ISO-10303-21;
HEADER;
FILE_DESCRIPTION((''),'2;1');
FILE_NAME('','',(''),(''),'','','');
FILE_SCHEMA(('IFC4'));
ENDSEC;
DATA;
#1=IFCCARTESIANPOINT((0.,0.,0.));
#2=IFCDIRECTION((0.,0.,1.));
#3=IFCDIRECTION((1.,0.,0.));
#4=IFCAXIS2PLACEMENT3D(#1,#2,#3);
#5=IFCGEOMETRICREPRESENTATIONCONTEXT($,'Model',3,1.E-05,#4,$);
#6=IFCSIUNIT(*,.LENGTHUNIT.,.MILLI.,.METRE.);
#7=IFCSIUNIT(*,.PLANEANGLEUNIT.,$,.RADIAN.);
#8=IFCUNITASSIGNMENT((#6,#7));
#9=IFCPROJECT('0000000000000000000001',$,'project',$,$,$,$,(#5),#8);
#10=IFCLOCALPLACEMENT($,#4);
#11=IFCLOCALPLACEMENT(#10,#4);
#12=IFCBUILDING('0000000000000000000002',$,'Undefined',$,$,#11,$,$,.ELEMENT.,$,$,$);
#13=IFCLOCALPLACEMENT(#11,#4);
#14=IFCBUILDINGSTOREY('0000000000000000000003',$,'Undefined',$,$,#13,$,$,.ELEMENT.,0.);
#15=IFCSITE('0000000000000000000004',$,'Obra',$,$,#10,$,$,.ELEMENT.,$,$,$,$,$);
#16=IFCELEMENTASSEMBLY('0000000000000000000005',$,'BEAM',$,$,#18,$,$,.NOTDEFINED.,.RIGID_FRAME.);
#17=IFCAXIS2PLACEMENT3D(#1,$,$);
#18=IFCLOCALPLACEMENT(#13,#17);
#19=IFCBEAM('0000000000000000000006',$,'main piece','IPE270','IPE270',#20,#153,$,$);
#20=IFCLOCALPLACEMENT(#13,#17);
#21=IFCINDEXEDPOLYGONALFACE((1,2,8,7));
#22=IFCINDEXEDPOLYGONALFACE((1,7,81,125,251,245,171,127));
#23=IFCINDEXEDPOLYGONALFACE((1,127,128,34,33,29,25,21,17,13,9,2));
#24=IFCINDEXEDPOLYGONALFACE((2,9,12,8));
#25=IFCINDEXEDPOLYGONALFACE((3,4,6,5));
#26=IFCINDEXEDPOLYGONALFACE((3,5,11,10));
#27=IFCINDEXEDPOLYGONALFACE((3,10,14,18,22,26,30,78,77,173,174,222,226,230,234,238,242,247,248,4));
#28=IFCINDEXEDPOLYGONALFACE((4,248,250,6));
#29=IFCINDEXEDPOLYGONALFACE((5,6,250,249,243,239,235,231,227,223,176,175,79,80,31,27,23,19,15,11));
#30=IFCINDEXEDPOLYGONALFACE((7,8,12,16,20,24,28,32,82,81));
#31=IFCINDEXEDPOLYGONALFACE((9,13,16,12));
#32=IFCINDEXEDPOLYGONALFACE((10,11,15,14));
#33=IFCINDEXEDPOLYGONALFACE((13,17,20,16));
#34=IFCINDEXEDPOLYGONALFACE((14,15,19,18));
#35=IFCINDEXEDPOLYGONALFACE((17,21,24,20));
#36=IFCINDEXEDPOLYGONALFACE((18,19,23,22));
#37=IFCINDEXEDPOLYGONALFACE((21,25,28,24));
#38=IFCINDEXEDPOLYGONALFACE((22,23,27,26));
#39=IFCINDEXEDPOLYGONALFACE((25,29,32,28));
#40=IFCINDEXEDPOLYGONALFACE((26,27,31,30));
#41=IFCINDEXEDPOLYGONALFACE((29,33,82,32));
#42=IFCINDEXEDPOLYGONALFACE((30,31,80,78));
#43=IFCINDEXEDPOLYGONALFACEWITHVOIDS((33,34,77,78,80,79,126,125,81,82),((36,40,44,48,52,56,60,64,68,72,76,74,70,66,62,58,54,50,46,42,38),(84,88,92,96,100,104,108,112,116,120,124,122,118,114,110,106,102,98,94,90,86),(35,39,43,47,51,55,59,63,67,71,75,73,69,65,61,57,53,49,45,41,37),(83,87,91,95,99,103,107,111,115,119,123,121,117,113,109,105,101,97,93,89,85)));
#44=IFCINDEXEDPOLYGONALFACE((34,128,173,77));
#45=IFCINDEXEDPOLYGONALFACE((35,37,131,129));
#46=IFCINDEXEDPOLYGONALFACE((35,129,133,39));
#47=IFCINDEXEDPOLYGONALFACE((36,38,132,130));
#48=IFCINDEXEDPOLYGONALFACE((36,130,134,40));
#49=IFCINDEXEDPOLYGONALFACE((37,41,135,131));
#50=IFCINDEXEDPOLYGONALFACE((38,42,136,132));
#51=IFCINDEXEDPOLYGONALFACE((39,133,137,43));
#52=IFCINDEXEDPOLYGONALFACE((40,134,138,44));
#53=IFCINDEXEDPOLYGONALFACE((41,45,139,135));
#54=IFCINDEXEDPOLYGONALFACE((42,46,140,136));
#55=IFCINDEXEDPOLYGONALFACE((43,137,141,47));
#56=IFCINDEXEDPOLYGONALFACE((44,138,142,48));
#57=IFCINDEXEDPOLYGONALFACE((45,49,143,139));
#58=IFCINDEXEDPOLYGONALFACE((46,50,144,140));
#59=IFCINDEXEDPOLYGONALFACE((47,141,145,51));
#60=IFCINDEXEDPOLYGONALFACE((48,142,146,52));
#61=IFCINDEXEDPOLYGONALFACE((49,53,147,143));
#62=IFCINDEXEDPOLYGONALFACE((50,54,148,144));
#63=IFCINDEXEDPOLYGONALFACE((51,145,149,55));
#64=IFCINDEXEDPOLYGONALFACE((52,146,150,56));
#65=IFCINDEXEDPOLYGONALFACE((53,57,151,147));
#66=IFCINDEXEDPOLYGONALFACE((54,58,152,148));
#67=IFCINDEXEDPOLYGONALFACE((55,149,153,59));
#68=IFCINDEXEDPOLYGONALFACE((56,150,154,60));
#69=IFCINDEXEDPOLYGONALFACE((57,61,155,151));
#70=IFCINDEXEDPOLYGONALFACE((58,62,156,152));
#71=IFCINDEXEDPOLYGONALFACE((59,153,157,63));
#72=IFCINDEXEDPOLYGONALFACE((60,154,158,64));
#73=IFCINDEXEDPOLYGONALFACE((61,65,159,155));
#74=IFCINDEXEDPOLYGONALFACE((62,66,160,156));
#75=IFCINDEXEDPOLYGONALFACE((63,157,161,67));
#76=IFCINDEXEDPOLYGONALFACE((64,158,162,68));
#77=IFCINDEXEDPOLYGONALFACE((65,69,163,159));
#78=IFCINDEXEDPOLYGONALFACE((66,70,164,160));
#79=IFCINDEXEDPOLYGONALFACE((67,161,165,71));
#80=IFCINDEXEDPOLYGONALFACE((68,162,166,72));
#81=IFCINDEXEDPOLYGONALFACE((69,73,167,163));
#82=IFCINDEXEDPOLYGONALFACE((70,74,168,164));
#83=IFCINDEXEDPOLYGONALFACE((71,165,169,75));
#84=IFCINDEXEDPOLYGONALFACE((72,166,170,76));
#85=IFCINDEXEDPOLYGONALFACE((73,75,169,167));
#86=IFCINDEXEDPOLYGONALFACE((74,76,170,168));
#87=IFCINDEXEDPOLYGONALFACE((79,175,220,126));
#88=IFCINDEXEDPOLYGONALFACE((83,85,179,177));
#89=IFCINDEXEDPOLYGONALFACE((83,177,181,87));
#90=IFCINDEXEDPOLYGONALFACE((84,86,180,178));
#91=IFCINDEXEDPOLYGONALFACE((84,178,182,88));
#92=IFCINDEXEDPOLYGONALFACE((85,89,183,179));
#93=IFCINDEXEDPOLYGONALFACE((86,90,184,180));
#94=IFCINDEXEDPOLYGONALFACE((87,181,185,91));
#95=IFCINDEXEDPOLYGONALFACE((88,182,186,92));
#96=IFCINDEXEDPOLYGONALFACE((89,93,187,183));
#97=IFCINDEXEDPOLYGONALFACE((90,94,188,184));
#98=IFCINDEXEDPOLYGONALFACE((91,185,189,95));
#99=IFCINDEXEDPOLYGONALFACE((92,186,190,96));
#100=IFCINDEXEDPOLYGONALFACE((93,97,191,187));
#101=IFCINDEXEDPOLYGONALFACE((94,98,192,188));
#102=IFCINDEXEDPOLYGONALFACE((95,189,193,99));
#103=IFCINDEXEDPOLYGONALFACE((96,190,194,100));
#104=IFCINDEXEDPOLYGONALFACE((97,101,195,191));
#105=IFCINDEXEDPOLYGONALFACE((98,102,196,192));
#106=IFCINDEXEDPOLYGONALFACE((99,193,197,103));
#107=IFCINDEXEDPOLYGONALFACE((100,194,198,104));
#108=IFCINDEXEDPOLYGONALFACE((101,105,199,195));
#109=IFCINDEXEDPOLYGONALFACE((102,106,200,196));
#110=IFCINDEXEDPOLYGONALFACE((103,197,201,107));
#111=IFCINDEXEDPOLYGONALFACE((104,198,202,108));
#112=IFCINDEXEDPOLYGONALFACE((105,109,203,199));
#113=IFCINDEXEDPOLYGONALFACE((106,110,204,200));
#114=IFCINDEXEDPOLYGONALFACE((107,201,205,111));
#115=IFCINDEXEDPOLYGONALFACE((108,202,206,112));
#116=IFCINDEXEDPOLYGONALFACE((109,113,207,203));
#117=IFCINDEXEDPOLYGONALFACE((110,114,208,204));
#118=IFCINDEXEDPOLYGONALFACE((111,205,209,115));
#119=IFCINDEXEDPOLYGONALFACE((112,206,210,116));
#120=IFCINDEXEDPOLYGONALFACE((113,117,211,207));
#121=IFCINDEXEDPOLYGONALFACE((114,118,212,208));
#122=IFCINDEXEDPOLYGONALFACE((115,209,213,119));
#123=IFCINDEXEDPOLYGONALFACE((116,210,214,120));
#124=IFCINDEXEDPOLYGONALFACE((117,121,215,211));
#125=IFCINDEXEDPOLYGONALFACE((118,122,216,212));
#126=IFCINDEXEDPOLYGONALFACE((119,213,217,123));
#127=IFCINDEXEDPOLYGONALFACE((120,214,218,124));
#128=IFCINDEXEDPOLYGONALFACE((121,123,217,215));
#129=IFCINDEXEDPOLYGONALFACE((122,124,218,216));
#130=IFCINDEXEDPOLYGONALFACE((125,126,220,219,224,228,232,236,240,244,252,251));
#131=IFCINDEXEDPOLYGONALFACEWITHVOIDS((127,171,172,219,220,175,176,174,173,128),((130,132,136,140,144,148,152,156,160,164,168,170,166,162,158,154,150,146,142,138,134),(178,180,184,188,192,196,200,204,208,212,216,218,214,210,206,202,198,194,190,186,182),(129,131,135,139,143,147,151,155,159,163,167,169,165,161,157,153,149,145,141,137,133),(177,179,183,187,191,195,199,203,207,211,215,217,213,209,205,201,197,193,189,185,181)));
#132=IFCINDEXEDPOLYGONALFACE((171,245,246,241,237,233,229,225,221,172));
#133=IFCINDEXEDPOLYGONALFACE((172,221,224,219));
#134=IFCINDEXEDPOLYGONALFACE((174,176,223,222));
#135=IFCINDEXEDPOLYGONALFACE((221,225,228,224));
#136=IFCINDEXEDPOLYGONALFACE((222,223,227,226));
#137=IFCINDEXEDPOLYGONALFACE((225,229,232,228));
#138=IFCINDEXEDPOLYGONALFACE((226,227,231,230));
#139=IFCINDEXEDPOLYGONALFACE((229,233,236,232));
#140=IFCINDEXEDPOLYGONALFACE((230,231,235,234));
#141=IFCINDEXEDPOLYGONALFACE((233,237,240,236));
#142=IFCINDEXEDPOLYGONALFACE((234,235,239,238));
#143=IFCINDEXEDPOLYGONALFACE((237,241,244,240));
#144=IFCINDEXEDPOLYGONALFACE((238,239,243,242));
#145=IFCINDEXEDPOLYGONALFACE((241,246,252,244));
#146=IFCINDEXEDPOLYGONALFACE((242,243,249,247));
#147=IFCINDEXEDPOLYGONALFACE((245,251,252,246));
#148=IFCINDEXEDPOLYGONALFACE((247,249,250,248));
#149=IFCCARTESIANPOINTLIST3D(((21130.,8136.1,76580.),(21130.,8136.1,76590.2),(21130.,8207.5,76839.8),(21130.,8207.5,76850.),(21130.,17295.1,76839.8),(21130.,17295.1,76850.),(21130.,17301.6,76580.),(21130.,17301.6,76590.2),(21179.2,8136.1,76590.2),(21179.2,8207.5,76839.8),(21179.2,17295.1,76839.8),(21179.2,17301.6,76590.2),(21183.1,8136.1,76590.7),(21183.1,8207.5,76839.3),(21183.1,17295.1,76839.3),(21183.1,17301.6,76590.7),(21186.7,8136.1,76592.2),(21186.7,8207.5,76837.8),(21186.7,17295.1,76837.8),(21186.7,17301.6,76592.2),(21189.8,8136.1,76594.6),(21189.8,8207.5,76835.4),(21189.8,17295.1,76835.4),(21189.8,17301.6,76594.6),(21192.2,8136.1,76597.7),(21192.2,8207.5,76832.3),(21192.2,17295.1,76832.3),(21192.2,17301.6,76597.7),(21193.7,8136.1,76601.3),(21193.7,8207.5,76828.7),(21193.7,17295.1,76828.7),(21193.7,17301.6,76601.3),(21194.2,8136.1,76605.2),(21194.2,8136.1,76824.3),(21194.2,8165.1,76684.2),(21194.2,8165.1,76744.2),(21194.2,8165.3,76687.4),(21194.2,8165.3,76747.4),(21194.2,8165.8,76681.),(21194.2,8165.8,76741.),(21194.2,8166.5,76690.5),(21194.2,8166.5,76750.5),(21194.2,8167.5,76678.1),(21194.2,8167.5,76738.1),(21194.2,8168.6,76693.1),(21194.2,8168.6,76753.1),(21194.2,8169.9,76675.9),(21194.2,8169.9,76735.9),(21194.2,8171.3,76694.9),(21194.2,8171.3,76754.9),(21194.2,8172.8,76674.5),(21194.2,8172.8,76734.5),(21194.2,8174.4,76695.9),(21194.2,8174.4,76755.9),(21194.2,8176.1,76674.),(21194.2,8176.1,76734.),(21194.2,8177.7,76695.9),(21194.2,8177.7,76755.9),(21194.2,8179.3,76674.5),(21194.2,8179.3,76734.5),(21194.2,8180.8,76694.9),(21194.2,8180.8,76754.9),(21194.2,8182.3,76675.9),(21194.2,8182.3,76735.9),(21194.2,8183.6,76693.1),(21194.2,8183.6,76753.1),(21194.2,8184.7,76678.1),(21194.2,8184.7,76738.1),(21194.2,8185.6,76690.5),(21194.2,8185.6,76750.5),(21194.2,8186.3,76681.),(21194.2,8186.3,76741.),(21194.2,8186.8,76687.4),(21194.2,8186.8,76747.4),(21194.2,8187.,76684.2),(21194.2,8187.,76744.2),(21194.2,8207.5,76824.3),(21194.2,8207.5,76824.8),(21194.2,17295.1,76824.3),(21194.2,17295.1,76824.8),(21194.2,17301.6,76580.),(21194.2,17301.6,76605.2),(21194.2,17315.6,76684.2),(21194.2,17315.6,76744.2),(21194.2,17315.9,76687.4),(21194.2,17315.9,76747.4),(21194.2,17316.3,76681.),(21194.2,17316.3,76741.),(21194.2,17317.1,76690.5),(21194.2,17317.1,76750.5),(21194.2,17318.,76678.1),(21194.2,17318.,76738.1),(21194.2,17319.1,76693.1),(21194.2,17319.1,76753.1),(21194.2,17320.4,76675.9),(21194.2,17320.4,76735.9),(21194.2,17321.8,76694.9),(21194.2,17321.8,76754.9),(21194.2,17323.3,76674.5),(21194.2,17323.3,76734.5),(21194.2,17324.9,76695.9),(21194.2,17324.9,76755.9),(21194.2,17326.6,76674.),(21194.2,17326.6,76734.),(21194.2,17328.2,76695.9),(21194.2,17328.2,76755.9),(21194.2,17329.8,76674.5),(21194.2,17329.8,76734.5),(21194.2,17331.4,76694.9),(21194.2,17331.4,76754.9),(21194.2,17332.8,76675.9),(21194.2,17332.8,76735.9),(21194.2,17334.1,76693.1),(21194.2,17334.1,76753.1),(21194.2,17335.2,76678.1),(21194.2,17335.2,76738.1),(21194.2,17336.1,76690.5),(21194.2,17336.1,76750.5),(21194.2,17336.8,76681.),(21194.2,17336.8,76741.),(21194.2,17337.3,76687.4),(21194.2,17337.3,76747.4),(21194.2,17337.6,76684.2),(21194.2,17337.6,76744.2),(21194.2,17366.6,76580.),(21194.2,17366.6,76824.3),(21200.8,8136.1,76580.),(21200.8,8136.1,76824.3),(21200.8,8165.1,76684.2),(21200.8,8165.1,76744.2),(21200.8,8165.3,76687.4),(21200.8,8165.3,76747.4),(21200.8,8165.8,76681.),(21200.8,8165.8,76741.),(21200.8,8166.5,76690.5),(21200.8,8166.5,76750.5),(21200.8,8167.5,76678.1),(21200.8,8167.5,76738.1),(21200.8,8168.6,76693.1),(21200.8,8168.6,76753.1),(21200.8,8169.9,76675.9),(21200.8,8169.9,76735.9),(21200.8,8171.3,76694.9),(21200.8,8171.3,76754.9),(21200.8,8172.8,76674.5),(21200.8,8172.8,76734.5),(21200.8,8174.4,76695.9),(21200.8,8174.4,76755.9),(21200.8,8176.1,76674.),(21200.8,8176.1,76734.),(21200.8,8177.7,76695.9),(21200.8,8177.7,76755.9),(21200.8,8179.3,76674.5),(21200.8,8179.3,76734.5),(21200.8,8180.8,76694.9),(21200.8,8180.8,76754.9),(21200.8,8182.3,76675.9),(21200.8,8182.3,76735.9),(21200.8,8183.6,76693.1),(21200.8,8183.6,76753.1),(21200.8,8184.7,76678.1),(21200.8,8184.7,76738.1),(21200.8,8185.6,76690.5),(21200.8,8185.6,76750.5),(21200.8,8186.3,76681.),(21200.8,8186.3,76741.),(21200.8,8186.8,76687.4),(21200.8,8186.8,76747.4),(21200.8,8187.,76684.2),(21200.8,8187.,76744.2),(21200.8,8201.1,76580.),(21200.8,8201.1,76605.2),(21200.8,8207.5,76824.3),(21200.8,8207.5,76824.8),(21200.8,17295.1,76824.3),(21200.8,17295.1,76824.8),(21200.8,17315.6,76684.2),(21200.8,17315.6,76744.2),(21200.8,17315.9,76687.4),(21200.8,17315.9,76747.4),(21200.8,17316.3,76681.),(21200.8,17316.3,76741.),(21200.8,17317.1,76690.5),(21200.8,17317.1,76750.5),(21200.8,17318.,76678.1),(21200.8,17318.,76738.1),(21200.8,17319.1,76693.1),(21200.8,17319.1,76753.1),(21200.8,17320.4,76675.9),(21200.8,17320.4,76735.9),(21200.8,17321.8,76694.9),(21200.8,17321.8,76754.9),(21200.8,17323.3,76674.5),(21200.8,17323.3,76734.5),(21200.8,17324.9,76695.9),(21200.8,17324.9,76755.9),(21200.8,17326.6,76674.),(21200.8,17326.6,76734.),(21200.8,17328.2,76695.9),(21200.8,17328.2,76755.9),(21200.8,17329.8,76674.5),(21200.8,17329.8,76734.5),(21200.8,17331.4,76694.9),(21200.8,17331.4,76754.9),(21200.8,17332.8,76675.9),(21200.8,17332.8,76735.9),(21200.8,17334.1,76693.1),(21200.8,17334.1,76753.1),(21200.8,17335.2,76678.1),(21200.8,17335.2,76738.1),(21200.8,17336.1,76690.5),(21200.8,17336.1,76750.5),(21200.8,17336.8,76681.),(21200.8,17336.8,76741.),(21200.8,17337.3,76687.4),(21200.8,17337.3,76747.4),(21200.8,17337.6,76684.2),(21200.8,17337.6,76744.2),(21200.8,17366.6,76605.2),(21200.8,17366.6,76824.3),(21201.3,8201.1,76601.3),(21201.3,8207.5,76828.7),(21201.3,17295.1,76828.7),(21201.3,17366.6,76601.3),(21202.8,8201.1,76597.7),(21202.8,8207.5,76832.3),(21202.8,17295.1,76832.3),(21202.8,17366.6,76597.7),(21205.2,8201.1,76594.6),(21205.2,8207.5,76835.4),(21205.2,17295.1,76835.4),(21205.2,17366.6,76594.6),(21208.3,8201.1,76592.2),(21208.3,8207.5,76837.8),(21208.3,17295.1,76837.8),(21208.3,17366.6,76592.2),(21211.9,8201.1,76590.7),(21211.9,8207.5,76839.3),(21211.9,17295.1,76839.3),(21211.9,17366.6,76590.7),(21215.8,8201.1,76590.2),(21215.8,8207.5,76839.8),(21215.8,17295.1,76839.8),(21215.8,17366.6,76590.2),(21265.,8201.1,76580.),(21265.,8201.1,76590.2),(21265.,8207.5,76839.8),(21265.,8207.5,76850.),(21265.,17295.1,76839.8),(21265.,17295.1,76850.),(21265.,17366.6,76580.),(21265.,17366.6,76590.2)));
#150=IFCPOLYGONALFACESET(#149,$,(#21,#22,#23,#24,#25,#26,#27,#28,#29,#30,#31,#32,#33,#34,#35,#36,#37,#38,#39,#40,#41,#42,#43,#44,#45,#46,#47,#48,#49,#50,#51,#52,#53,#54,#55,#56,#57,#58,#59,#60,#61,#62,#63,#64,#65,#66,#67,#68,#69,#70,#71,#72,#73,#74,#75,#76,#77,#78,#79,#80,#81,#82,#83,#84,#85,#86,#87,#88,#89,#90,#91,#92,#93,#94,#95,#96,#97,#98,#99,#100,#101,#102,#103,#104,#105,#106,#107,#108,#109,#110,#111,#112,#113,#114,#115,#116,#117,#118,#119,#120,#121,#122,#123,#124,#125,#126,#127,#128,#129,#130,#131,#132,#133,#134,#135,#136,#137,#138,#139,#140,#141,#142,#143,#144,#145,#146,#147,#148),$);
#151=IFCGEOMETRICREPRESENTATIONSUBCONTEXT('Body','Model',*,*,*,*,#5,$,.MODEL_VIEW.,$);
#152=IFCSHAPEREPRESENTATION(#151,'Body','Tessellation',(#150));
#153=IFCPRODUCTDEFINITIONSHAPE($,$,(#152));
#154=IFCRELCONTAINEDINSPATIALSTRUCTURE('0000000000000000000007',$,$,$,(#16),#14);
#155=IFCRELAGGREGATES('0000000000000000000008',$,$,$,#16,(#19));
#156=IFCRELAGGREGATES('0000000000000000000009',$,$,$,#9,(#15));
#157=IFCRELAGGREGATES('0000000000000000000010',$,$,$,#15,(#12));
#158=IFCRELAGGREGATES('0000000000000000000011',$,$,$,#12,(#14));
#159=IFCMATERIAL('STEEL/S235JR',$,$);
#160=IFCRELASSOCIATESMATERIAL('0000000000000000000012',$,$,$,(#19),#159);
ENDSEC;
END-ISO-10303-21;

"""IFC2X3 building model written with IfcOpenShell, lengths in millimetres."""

from ifc_helpers import new_model, si_unit, frame, origin_with_axes, origin_2d_with_axis, place, context, subcontext, project, spatial, rectangle, circle, i_section, extrude, clip, halfspace, source, transform, mapped, material, element, aggregate, save


model = new_model("IFC2X3")

# Units and contexts
model_context = context("Model", 3, precision=1e-05, world=origin_with_axes())
body_context = subcontext(model_context, "Body", "Model", "MODEL_VIEW")
ifc_project = project(units=[si_unit("LENGTHUNIT", "METRE", prefix="MILLI"), si_unit("PLANEANGLEUNIT", "RADIAN")], contexts=[model_context])

# Site, building, storey
site_placement = place(None, origin_with_axes())
site = spatial("IfcSite", under=ifc_project, at=site_placement, Name="Obra", CompositionType="ELEMENT")
building_placement = place(site_placement, origin_with_axes())
building = spatial("IfcBuilding", under=site, at=building_placement, Name="Undefined", CompositionType="ELEMENT")
storey_placement = place(building_placement, origin_with_axes())
storey = spatial("IfcBuildingStorey", under=building, at=storey_placement, Name="Undefined", CompositionType="ELEMENT", Elevation=0.0)

# Shared definitions
ifc_material = material(Name="STEEL/S235JR")

# Element assembly, beam, openings
assembly_1_placement = place(storey_placement, origin_with_axes())
assembly_1 = element("IfcElementAssembly", 1, at=assembly_1_placement, inside=storey, Name="BEAM", AssemblyPlace="NOTDEFINED", PredefinedType="RIGID_FRAME")
beam_1_placement = place(assembly_1_placement, frame((21197.5, 8217.5, 76715.0), z_axis=(0.0, 0.0, 1.0), x_axis=(0.0, 1.0, 0.0)))
beam_1 = element("IfcBeam", 2, at=beam_1_placement, material=ifc_material, Name="main piece", Description="IPE270", ObjectType="IPE270", context=body_context, shape_type="Clipping", body=[
    clip(clip(extrude(i_section(OverallWidth=135.0, OverallDepth=270.0, WebThickness=6.6, FlangeThickness=10.2, FilletRadius=15.0, at=origin_2d_with_axis()), frame((9149.1, 0.0, 0.0), z_axis=(-1.0, 0.0, 0.0), x_axis=(0.0, -1.0, 0.0)), (0.0, 0.0, 1.0), 9230.5), halfspace(frame((9149.1, 0.0, -235.0), z_axis=(-1.0, 0.0, 0.0), x_axis=(0.0, 1.0, 0.0)), True)), halfspace(frame((-81.5, 0.0, -235.0), z_axis=(1.0, 0.0, 0.0), x_axis=(0.0, -1.0, 0.0)), True)),
])
opening_1_placement = place(assembly_1_placement, frame((21197.5, 8217.5, 76715.0), z_axis=(0.0, 0.0, 1.0), x_axis=(0.0, 1.0, 0.0)))
element("IfcOpeningElement", 3, at=opening_1_placement, cuts=beam_1, ObjectType="Recess", context=body_context, shape_type="SweptSolid", body=[
    extrude(rectangle(XDim=75.0, YDim=300.0, at=origin_2d_with_axis()), frame((9121.6, 153.3, 124.3), z_axis=(0.0, 0.0, -1.0), x_axis=(-1.0, 0.0, 0.0)), (0.0, 0.0, 1.0), 278.6),
])
opening_2_placement = place(assembly_1_placement, frame((21197.5, 8217.5, 76715.0), z_axis=(0.0, 0.0, 1.0), x_axis=(0.0, 1.0, 0.0)))
element("IfcOpeningElement", 4, at=opening_2_placement, cuts=beam_1, ObjectType="Recess", context=body_context, shape_type="SweptSolid", body=[
    extrude(rectangle(XDim=26.7, YDim=83.5, at=origin_2d_with_axis()), frame((9119.3, 68.5, 122.7), z_axis=(0.0, -1.0, 0.0), x_axis=(0.0, 0.0, -1.0)), (0.0, 0.0, 1.0), 137.0),
])
opening_3_placement = place(assembly_1_placement, frame((21197.5, 8217.5, 76715.0), z_axis=(0.0, 0.0, 1.0), x_axis=(0.0, 1.0, 0.0)))
element("IfcOpeningElement", 5, at=opening_3_placement, cuts=beam_1, ObjectType="Recess", context=body_context, shape_type="SweptSolid", body=[
    extrude(rectangle(XDim=75.0, YDim=300.0, at=origin_2d_with_axis()), frame((-54.0, -153.3, 124.3), z_axis=(0.0, 0.0, -1.0), x_axis=(1.0, 0.0, 0.0)), (0.0, 0.0, 1.0), 278.6),
])
opening_4_placement = place(assembly_1_placement, frame((21197.5, 8217.5, 76715.0), z_axis=(0.0, 0.0, 1.0), x_axis=(0.0, 1.0, 0.0)))
element("IfcOpeningElement", 6, at=opening_4_placement, cuts=beam_1, ObjectType="Recess", context=body_context, shape_type="SweptSolid", body=[
    extrude(rectangle(XDim=26.7, YDim=83.5, at=origin_2d_with_axis()), frame((-51.7, -68.5, 122.7), z_axis=(0.0, 1.0, 0.0), x_axis=(0.0, 0.0, -1.0)), (0.0, 0.0, 1.0), 137.0),
])
shared_shape_1 = source(origin_with_axes(), body_context, "Body", "SweptSolid", [
    extrude(circle(Radius=11.0, at=origin_2d_with_axis()), frame((0.0, -3.4, 0.0), z_axis=(0.0, 1.0, 0.0), x_axis=(1.0, 0.0, 0.0)), (0.0, 0.0, 1.0), 6.8),
])
opening_5_placement = place(assembly_1_placement, frame((21197.5, 17366.6, 76850.0), z_axis=(0.0, -1.0, 0.0), x_axis=(0.0, 0.0, -1.0)))
element("IfcOpeningElement", 7, at=opening_5_placement, cuts=beam_1, ObjectType="Opening", context=body_context, shape_type="MappedRepresentation", body=[
    mapped(shared_shape_1, transform((105.0, 0.0, 40.0))),
    mapped(shared_shape_1, transform((165.0, 0.0, 40.0))),
])
opening_6_placement = place(assembly_1_placement, frame((21197.5, 8136.1, 76850.0), z_axis=(0.0, 1.0, 0.0), x_axis=(0.0, 0.0, -1.0)))
element("IfcOpeningElement", 8, at=opening_6_placement, cuts=beam_1, ObjectType="Opening", context=body_context, shape_type="MappedRepresentation", body=[
    mapped(shared_shape_1, transform((105.0, 0.0, 40.0))),
    mapped(shared_shape_1, transform((165.0, 0.0, 40.0))),
])
aggregate(assembly_1, [beam_1])

save(model, "model.ifc")
